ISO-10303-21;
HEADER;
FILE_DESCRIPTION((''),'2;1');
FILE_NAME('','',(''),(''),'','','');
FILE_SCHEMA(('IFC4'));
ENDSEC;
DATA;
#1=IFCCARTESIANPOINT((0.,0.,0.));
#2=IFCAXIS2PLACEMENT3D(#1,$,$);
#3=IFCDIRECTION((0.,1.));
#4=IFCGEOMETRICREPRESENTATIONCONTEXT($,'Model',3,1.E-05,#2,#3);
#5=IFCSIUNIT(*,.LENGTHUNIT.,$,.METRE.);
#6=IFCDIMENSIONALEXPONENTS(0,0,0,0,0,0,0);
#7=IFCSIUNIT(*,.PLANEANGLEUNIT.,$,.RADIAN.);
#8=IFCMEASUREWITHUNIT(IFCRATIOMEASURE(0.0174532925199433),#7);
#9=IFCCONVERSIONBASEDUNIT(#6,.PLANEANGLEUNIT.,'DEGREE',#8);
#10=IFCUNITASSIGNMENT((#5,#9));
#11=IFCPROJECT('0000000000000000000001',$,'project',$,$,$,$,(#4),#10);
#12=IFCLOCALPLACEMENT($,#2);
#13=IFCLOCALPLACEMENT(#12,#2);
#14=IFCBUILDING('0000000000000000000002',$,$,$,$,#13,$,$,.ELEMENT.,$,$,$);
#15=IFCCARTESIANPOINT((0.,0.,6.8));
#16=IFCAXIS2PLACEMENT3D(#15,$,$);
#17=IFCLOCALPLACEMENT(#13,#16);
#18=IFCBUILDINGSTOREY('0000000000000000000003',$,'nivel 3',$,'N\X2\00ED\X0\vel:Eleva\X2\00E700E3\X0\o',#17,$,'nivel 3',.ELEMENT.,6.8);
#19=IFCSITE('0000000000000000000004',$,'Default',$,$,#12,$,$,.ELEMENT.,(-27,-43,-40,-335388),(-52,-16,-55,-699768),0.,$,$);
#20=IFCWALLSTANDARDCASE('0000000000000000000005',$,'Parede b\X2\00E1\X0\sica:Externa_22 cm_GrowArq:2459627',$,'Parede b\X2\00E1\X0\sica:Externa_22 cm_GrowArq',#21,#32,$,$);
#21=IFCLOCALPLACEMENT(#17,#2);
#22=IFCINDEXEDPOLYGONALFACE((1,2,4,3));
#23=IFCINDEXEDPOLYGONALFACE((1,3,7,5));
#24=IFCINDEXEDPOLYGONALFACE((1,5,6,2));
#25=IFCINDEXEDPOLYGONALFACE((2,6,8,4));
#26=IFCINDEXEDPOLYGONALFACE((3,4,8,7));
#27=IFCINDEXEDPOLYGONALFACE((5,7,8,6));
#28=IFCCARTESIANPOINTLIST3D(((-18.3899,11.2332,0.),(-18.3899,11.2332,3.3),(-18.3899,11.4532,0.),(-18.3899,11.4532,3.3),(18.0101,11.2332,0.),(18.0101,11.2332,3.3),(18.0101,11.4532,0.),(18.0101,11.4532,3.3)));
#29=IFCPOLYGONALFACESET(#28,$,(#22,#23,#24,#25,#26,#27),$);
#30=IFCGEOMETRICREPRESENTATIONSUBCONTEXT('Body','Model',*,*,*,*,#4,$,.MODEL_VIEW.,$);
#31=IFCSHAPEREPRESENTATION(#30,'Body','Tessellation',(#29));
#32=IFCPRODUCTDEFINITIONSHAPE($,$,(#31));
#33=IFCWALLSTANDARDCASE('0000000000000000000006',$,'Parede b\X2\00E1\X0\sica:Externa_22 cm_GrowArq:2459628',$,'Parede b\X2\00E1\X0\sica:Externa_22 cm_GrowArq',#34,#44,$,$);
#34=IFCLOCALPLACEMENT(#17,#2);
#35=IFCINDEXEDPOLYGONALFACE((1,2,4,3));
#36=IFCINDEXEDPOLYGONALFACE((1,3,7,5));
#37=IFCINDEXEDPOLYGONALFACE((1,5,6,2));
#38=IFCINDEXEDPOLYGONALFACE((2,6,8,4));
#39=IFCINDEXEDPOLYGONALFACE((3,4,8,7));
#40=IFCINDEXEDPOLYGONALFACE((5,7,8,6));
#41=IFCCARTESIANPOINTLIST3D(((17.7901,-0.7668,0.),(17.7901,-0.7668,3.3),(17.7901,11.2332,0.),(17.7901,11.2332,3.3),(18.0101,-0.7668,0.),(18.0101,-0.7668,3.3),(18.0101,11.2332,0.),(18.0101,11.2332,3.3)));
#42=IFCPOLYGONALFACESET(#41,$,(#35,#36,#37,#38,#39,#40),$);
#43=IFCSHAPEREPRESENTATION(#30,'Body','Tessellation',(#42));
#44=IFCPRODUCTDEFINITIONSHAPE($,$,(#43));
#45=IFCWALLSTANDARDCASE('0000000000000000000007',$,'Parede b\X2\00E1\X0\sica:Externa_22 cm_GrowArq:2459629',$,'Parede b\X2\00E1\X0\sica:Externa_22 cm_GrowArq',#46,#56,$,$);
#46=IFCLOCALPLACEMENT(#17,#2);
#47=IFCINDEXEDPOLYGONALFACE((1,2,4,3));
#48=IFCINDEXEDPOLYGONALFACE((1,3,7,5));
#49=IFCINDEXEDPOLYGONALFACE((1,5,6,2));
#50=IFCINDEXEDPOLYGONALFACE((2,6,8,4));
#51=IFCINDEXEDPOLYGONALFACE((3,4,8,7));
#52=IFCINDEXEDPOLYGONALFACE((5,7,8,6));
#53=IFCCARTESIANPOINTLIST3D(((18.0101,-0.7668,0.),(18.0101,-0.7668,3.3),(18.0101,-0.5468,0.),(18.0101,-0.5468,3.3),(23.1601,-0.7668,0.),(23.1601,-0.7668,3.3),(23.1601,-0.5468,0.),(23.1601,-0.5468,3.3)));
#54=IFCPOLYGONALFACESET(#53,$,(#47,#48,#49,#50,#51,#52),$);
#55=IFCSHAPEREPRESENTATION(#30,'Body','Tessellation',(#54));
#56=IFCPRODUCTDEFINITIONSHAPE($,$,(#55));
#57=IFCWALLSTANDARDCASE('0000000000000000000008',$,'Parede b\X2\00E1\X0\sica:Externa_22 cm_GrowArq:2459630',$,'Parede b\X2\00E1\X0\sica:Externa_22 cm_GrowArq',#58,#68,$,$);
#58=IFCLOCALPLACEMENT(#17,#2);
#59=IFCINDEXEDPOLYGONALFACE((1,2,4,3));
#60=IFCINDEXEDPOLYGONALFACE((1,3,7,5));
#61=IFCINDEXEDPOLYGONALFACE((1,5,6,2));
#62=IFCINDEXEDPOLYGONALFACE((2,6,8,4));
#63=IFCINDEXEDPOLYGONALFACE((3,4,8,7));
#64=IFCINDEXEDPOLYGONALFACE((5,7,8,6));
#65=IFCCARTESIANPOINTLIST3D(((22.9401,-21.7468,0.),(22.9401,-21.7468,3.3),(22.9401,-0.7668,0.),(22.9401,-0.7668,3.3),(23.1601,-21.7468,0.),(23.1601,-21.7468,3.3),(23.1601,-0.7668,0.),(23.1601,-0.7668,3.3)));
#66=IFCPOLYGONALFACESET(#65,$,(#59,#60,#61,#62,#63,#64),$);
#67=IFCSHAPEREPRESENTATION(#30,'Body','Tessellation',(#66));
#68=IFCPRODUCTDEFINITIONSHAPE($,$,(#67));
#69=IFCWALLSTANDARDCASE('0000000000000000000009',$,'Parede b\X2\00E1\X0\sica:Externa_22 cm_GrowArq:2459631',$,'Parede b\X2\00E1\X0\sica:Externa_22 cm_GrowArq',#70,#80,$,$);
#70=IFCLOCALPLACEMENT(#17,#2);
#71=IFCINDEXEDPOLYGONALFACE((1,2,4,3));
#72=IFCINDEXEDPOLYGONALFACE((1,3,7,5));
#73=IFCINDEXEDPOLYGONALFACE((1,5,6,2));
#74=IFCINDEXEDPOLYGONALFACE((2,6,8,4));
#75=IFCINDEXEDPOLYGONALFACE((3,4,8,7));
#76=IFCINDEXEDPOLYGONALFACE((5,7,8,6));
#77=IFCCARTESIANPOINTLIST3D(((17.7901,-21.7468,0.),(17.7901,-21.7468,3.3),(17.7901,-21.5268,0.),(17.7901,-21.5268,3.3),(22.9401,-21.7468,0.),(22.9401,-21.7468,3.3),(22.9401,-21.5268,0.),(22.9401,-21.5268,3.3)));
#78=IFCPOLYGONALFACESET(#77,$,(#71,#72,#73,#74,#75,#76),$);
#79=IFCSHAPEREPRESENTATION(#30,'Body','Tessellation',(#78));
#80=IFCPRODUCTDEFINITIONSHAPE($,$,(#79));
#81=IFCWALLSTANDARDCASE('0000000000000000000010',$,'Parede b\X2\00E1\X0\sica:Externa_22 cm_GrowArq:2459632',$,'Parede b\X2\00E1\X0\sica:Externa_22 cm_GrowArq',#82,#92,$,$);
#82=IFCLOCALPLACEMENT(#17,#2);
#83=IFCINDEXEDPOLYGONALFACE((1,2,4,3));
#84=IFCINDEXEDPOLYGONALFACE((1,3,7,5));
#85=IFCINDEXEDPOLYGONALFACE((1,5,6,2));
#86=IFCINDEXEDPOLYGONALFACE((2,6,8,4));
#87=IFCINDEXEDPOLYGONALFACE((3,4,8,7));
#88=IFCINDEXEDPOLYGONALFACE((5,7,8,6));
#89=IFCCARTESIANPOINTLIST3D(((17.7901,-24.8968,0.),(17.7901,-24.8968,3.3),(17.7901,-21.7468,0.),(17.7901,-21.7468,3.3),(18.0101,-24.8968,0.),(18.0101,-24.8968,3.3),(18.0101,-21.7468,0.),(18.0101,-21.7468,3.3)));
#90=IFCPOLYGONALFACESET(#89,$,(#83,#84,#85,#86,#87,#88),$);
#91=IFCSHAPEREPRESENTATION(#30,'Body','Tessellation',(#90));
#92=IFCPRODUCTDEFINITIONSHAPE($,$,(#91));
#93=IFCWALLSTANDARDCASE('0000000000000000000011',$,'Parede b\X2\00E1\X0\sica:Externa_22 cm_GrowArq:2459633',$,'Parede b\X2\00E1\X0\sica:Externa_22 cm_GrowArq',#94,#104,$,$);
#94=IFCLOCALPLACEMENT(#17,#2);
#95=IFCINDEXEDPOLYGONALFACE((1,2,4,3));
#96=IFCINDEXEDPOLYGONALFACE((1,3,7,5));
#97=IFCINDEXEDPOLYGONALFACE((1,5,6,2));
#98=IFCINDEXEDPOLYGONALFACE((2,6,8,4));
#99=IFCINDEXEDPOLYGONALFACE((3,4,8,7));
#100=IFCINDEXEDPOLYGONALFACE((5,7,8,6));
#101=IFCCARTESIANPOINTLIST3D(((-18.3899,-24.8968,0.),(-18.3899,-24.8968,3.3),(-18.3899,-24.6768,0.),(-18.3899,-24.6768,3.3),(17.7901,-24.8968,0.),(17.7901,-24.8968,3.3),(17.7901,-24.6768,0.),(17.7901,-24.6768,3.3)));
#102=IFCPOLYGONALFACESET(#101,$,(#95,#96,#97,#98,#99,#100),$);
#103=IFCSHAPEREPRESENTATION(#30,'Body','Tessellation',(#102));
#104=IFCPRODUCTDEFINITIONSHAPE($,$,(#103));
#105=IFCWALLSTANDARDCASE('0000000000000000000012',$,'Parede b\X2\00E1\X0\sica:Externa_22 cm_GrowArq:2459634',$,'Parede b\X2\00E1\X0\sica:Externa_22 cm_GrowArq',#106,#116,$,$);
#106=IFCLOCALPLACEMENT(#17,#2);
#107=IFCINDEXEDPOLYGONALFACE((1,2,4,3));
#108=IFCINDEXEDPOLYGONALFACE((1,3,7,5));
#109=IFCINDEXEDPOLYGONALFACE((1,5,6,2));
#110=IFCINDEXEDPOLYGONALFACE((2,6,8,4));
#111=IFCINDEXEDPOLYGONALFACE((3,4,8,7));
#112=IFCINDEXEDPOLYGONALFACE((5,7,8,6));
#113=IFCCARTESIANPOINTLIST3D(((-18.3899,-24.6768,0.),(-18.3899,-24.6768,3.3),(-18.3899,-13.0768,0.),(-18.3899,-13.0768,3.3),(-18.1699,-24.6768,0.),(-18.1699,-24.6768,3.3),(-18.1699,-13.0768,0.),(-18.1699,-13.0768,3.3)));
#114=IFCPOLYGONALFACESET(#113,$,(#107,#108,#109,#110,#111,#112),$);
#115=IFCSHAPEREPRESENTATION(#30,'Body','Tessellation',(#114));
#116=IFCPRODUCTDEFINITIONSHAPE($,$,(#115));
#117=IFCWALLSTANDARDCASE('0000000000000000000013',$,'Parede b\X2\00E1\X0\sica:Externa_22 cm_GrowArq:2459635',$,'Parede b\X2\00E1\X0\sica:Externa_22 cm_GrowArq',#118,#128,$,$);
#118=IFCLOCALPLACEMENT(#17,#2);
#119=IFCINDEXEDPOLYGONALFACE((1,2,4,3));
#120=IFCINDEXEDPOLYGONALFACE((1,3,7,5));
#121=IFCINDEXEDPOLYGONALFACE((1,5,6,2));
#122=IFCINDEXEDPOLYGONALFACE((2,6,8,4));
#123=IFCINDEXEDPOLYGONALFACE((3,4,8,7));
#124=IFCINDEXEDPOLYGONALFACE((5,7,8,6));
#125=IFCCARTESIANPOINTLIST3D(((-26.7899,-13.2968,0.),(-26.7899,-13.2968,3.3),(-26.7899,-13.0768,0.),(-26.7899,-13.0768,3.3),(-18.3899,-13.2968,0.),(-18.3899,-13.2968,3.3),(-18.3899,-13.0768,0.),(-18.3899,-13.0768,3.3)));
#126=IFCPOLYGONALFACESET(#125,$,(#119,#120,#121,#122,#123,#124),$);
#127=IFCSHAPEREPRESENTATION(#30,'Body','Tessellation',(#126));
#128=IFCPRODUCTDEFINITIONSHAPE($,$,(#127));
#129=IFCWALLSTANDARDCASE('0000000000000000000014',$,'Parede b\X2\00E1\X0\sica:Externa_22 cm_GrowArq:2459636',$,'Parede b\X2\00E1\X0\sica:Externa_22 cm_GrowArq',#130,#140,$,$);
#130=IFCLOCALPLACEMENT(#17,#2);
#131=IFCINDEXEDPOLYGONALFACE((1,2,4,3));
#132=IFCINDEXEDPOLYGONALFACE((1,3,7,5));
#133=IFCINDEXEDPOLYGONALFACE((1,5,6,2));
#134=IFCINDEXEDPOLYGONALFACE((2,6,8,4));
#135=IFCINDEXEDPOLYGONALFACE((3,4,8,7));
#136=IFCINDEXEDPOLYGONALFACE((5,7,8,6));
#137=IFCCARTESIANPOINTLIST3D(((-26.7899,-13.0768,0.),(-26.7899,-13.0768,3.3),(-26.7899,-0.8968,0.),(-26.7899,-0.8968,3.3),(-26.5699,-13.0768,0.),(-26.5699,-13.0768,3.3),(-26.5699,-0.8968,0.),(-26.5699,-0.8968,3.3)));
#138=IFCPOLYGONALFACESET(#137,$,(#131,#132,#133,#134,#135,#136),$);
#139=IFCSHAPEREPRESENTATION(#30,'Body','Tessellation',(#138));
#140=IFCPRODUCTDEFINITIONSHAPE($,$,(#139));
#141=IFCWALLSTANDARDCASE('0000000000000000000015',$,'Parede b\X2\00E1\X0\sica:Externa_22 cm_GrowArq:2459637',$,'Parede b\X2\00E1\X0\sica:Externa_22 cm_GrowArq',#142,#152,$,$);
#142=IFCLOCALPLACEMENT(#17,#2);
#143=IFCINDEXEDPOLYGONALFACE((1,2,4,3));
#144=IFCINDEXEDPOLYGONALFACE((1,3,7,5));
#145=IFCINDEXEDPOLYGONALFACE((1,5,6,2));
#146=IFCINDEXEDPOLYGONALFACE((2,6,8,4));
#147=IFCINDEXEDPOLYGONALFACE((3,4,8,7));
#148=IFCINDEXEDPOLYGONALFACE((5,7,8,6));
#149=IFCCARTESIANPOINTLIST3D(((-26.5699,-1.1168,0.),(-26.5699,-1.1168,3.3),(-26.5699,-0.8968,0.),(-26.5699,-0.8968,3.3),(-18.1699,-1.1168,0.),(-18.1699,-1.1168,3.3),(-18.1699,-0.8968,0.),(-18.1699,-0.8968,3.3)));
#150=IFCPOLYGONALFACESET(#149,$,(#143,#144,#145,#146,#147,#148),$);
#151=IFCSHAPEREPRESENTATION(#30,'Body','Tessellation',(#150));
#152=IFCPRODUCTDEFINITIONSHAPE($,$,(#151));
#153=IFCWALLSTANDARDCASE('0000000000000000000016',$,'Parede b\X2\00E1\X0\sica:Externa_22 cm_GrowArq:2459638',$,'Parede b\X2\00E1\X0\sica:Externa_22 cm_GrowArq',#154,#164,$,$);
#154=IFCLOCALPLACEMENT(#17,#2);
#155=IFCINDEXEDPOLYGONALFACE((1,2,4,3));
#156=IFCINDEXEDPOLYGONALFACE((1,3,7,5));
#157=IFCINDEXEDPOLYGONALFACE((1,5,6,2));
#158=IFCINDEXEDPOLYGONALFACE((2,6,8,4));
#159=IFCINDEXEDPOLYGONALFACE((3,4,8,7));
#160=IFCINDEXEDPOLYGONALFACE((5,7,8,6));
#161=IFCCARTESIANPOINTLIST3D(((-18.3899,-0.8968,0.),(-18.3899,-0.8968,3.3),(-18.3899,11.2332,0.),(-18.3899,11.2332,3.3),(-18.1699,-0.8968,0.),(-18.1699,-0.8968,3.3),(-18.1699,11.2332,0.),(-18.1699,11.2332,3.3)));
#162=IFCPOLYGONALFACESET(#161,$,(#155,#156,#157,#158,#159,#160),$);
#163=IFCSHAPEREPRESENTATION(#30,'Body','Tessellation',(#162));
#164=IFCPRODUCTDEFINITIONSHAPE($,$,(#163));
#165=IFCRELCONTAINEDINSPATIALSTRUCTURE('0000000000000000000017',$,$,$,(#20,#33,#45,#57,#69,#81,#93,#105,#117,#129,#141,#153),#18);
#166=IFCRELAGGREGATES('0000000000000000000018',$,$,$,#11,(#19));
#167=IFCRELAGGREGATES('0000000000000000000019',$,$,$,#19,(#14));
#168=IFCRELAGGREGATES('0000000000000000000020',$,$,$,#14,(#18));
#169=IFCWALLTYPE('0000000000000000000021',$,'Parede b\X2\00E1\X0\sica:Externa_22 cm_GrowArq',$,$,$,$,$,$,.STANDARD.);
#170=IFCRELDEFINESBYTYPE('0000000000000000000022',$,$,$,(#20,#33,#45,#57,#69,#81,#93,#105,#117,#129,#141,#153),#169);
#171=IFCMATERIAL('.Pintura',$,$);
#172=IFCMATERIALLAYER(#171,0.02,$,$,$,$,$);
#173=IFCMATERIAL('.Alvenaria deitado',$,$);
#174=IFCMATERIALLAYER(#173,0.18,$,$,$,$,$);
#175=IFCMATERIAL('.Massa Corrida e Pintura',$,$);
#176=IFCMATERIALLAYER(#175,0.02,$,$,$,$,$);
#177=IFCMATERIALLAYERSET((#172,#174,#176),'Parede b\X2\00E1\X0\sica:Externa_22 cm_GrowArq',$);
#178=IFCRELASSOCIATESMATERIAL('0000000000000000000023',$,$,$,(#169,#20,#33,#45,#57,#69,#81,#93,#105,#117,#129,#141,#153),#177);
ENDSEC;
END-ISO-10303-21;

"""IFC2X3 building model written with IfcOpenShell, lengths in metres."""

from ifc_helpers import new_model, entity, si_unit, converted_unit, direction, frame, frame_2d, origin, place, context, subcontext, project, spatial, rectangle, extrude, material, layer, layer_set, layer_usage, type_object, element, save


model = new_model("IFC2X3")

# Units and contexts
model_context = context("Model", 3, precision=1e-05, world=origin(), true_north=direction((0.0, 1.0)))
body_context = subcontext(model_context, "Body", "Model", "MODEL_VIEW")
ifc_project = project(units=[si_unit("LENGTHUNIT", "METRE"), converted_unit("PLANEANGLEUNIT", "DEGREE", entity("IfcRatioMeasure", 0.0174532925199433), si_unit("PLANEANGLEUNIT", "RADIAN"), dimensions=[0, 0, 0, 0, 0, 0, 0])], contexts=[model_context])

# Site, building, storey
site_placement = place(None, origin())
site = spatial("IfcSite", under=ifc_project, at=site_placement, Name="Default", CompositionType="ELEMENT", RefLatitude=(-27, -43, -40, -335388), RefLongitude=(-52, -16, -55, -699768), RefElevation=0.0)
building_placement = place(site_placement, origin())
building = spatial("IfcBuilding", under=site, at=building_placement, CompositionType="ELEMENT")
storey_placement = place(building_placement, frame((0.0, 0.0, 6.8)))
storey = spatial("IfcBuildingStorey", under=building, at=storey_placement, Name="nivel 3", ObjectType="Nível:Elevação", LongName="nivel 3", CompositionType="ELEMENT", Elevation=6.8)

# Walls
ifc_material_1 = material(Name=".Pintura")
ifc_layer_1 = layer(ifc_material_1, 0.02)
ifc_material_2 = material(Name=".Alvenaria deitado")
ifc_layer_2 = layer(ifc_material_2, 0.18)
ifc_material_3 = material(Name=".Massa Corrida e Pintura")
ifc_layer_3 = layer(ifc_material_3, 0.02)
ifc_layer_set_1 = layer_set([ifc_layer_1, ifc_layer_2, ifc_layer_3], Name="Parede básica:Externa_22 cm_GrowArq")
ifc_layer_usage_1 = layer_usage(ifc_layer_set_1, "AXIS2", "NEGATIVE", 0.11)
wall_type = type_object("IfcWallType", Name="Parede básica:Externa_22 cm_GrowArq", PredefinedType="STANDARD", material=ifc_layer_set_1)
wall_1_placement = place(storey_placement, frame((-18.3899, 11.3432, 0.0)))
element("IfcWallStandardCase", 1, at=wall_1_placement, inside=storey, type_object=wall_type, material=ifc_layer_usage_1, Name="Parede básica:Externa_22 cm_GrowArq:2459627", ObjectType="Parede básica:Externa_22 cm_GrowArq", context=body_context, shape_type="SweptSolid", body=[
    extrude(rectangle(XDim=36.4, YDim=0.22, at=frame_2d((18.2, 0.0), x_axis=(-1.0, 0.0))), origin(), (0.0, 0.0, 1.0), 3.3),
])
ifc_layer_usage_2 = layer_usage(ifc_layer_set_1, "AXIS2", "NEGATIVE", 0.11)
wall_2_placement = place(storey_placement, frame((17.9001, 11.2332, 0.0), z_axis=(0.0, 0.0, 1.0), x_axis=(0.0, -1.0, 0.0)))
element("IfcWallStandardCase", 2, at=wall_2_placement, inside=storey, type_object=wall_type, material=ifc_layer_usage_2, Name="Parede básica:Externa_22 cm_GrowArq:2459628", ObjectType="Parede básica:Externa_22 cm_GrowArq", context=body_context, shape_type="SweptSolid", body=[
    extrude(rectangle(XDim=12.0, YDim=0.22, at=frame_2d((6.0, 0.0), x_axis=(-1.0, 0.0))), origin(), (0.0, 0.0, 1.0), 3.3),
])
ifc_layer_usage_3 = layer_usage(ifc_layer_set_1, "AXIS2", "NEGATIVE", 0.11)
wall_3_placement = place(storey_placement, frame((18.0101, -0.6568, 0.0)))
element("IfcWallStandardCase", 3, at=wall_3_placement, inside=storey, type_object=wall_type, material=ifc_layer_usage_3, Name="Parede básica:Externa_22 cm_GrowArq:2459629", ObjectType="Parede básica:Externa_22 cm_GrowArq", context=body_context, shape_type="SweptSolid", body=[
    extrude(rectangle(XDim=5.15, YDim=0.22, at=frame_2d((2.575, 0.0), x_axis=(-1.0, 0.0))), origin(), (0.0, 0.0, 1.0), 3.3),
])
ifc_layer_usage_4 = layer_usage(ifc_layer_set_1, "AXIS2", "NEGATIVE", 0.11)
wall_4_placement = place(storey_placement, frame((23.0501, -0.7668, 0.0), z_axis=(0.0, 0.0, 1.0), x_axis=(0.0, -1.0, 0.0)))
element("IfcWallStandardCase", 4, at=wall_4_placement, inside=storey, type_object=wall_type, material=ifc_layer_usage_4, Name="Parede básica:Externa_22 cm_GrowArq:2459630", ObjectType="Parede básica:Externa_22 cm_GrowArq", context=body_context, shape_type="SweptSolid", body=[
    extrude(rectangle(XDim=20.98, YDim=0.22, at=frame_2d((10.49, 0.0), x_axis=(-1.0, 0.0))), origin(), (0.0, 0.0, 1.0), 3.3),
])
ifc_layer_usage_5 = layer_usage(ifc_layer_set_1, "AXIS2", "NEGATIVE", 0.11)
wall_5_placement = place(storey_placement, frame((22.9401, -21.6368, 0.0), z_axis=(0.0, 0.0, 1.0), x_axis=(-1.0, 0.0, 0.0)))
element("IfcWallStandardCase", 5, at=wall_5_placement, inside=storey, type_object=wall_type, material=ifc_layer_usage_5, Name="Parede básica:Externa_22 cm_GrowArq:2459631", ObjectType="Parede básica:Externa_22 cm_GrowArq", context=body_context, shape_type="SweptSolid", body=[
    extrude(rectangle(XDim=5.15, YDim=0.22, at=frame_2d((2.575, 0.0), x_axis=(-1.0, 0.0))), origin(), (0.0, 0.0, 1.0), 3.3),
])
ifc_layer_usage_6 = layer_usage(ifc_layer_set_1, "AXIS2", "NEGATIVE", 0.11)
wall_6_placement = place(storey_placement, frame((17.9001, -21.7468, 0.0), z_axis=(0.0, 0.0, 1.0), x_axis=(0.0, -1.0, 0.0)))
element("IfcWallStandardCase", 6, at=wall_6_placement, inside=storey, type_object=wall_type, material=ifc_layer_usage_6, Name="Parede básica:Externa_22 cm_GrowArq:2459632", ObjectType="Parede básica:Externa_22 cm_GrowArq", context=body_context, shape_type="SweptSolid", body=[
    extrude(rectangle(XDim=3.15, YDim=0.22, at=frame_2d((1.575, 0.0), x_axis=(-1.0, 0.0))), origin(), (0.0, 0.0, 1.0), 3.3),
])
ifc_layer_usage_7 = layer_usage(ifc_layer_set_1, "AXIS2", "NEGATIVE", 0.11)
wall_7_placement = place(storey_placement, frame((17.7901, -24.7868, 0.0), z_axis=(0.0, 0.0, 1.0), x_axis=(-1.0, 0.0, 0.0)))
element("IfcWallStandardCase", 7, at=wall_7_placement, inside=storey, type_object=wall_type, material=ifc_layer_usage_7, Name="Parede básica:Externa_22 cm_GrowArq:2459633", ObjectType="Parede básica:Externa_22 cm_GrowArq", context=body_context, shape_type="SweptSolid", body=[
    extrude(rectangle(XDim=36.18, YDim=0.22, at=frame_2d((18.09, 0.0), x_axis=(-1.0, 0.0))), origin(), (0.0, 0.0, 1.0), 3.3),
])
ifc_layer_usage_8 = layer_usage(ifc_layer_set_1, "AXIS2", "NEGATIVE", 0.11)
wall_8_placement = place(storey_placement, frame((-18.2799, -24.6768, 0.0), z_axis=(0.0, 0.0, 1.0), x_axis=(0.0, 1.0, 0.0)))
element("IfcWallStandardCase", 8, at=wall_8_placement, inside=storey, type_object=wall_type, material=ifc_layer_usage_8, Name="Parede básica:Externa_22 cm_GrowArq:2459634", ObjectType="Parede básica:Externa_22 cm_GrowArq", context=body_context, shape_type="SweptSolid", body=[
    extrude(rectangle(XDim=11.6, YDim=0.22, at=frame_2d((5.8, 0.0), x_axis=(-1.0, 0.0))), origin(), (0.0, 0.0, 1.0), 3.3),
])
ifc_layer_usage_9 = layer_usage(ifc_layer_set_1, "AXIS2", "NEGATIVE", 0.11)
wall_9_placement = place(storey_placement, frame((-18.3899, -13.1868, 0.0), z_axis=(0.0, 0.0, 1.0), x_axis=(-1.0, 0.0, 0.0)))
element("IfcWallStandardCase", 9, at=wall_9_placement, inside=storey, type_object=wall_type, material=ifc_layer_usage_9, Name="Parede básica:Externa_22 cm_GrowArq:2459635", ObjectType="Parede básica:Externa_22 cm_GrowArq", context=body_context, shape_type="SweptSolid", body=[
    extrude(rectangle(XDim=8.4, YDim=0.22, at=frame_2d((4.2, 0.0), x_axis=(-1.0, 0.0))), origin(), (0.0, 0.0, 1.0), 3.3),
])
ifc_layer_usage_10 = layer_usage(ifc_layer_set_1, "AXIS2", "NEGATIVE", 0.11)
wall_10_placement = place(storey_placement, frame((-26.6799, -13.0768, 0.0), z_axis=(0.0, 0.0, 1.0), x_axis=(0.0, 1.0, 0.0)))
element("IfcWallStandardCase", 10, at=wall_10_placement, inside=storey, type_object=wall_type, material=ifc_layer_usage_10, Name="Parede básica:Externa_22 cm_GrowArq:2459636", ObjectType="Parede básica:Externa_22 cm_GrowArq", context=body_context, shape_type="SweptSolid", body=[
    extrude(rectangle(XDim=12.18, YDim=0.22, at=frame_2d((6.09, 0.0), x_axis=(-1.0, 0.0))), origin(), (0.0, 0.0, 1.0), 3.3),
])
ifc_layer_usage_11 = layer_usage(ifc_layer_set_1, "AXIS2", "NEGATIVE", 0.11)
wall_11_placement = place(storey_placement, frame((-26.5699, -1.0068, 0.0)))
element("IfcWallStandardCase", 11, at=wall_11_placement, inside=storey, type_object=wall_type, material=ifc_layer_usage_11, Name="Parede básica:Externa_22 cm_GrowArq:2459637", ObjectType="Parede básica:Externa_22 cm_GrowArq", context=body_context, shape_type="SweptSolid", body=[
    extrude(rectangle(XDim=8.4, YDim=0.22, at=frame_2d((4.2, 0.0), x_axis=(-1.0, 0.0))), origin(), (0.0, 0.0, 1.0), 3.3),
])
ifc_layer_usage_12 = layer_usage(ifc_layer_set_1, "AXIS2", "NEGATIVE", 0.11)
wall_12_placement = place(storey_placement, frame((-18.2799, -0.8968, 0.0), z_axis=(0.0, 0.0, 1.0), x_axis=(0.0, 1.0, 0.0)))
element("IfcWallStandardCase", 12, at=wall_12_placement, inside=storey, type_object=wall_type, material=ifc_layer_usage_12, Name="Parede básica:Externa_22 cm_GrowArq:2459638", ObjectType="Parede básica:Externa_22 cm_GrowArq", context=body_context, shape_type="SweptSolid", body=[
    extrude(rectangle(XDim=12.13, YDim=0.22, at=frame_2d((6.065, 0.0), x_axis=(-1.0, 0.0))), origin(), (0.0, 0.0, 1.0), 3.3),
])

save(model, "model.ifc")
